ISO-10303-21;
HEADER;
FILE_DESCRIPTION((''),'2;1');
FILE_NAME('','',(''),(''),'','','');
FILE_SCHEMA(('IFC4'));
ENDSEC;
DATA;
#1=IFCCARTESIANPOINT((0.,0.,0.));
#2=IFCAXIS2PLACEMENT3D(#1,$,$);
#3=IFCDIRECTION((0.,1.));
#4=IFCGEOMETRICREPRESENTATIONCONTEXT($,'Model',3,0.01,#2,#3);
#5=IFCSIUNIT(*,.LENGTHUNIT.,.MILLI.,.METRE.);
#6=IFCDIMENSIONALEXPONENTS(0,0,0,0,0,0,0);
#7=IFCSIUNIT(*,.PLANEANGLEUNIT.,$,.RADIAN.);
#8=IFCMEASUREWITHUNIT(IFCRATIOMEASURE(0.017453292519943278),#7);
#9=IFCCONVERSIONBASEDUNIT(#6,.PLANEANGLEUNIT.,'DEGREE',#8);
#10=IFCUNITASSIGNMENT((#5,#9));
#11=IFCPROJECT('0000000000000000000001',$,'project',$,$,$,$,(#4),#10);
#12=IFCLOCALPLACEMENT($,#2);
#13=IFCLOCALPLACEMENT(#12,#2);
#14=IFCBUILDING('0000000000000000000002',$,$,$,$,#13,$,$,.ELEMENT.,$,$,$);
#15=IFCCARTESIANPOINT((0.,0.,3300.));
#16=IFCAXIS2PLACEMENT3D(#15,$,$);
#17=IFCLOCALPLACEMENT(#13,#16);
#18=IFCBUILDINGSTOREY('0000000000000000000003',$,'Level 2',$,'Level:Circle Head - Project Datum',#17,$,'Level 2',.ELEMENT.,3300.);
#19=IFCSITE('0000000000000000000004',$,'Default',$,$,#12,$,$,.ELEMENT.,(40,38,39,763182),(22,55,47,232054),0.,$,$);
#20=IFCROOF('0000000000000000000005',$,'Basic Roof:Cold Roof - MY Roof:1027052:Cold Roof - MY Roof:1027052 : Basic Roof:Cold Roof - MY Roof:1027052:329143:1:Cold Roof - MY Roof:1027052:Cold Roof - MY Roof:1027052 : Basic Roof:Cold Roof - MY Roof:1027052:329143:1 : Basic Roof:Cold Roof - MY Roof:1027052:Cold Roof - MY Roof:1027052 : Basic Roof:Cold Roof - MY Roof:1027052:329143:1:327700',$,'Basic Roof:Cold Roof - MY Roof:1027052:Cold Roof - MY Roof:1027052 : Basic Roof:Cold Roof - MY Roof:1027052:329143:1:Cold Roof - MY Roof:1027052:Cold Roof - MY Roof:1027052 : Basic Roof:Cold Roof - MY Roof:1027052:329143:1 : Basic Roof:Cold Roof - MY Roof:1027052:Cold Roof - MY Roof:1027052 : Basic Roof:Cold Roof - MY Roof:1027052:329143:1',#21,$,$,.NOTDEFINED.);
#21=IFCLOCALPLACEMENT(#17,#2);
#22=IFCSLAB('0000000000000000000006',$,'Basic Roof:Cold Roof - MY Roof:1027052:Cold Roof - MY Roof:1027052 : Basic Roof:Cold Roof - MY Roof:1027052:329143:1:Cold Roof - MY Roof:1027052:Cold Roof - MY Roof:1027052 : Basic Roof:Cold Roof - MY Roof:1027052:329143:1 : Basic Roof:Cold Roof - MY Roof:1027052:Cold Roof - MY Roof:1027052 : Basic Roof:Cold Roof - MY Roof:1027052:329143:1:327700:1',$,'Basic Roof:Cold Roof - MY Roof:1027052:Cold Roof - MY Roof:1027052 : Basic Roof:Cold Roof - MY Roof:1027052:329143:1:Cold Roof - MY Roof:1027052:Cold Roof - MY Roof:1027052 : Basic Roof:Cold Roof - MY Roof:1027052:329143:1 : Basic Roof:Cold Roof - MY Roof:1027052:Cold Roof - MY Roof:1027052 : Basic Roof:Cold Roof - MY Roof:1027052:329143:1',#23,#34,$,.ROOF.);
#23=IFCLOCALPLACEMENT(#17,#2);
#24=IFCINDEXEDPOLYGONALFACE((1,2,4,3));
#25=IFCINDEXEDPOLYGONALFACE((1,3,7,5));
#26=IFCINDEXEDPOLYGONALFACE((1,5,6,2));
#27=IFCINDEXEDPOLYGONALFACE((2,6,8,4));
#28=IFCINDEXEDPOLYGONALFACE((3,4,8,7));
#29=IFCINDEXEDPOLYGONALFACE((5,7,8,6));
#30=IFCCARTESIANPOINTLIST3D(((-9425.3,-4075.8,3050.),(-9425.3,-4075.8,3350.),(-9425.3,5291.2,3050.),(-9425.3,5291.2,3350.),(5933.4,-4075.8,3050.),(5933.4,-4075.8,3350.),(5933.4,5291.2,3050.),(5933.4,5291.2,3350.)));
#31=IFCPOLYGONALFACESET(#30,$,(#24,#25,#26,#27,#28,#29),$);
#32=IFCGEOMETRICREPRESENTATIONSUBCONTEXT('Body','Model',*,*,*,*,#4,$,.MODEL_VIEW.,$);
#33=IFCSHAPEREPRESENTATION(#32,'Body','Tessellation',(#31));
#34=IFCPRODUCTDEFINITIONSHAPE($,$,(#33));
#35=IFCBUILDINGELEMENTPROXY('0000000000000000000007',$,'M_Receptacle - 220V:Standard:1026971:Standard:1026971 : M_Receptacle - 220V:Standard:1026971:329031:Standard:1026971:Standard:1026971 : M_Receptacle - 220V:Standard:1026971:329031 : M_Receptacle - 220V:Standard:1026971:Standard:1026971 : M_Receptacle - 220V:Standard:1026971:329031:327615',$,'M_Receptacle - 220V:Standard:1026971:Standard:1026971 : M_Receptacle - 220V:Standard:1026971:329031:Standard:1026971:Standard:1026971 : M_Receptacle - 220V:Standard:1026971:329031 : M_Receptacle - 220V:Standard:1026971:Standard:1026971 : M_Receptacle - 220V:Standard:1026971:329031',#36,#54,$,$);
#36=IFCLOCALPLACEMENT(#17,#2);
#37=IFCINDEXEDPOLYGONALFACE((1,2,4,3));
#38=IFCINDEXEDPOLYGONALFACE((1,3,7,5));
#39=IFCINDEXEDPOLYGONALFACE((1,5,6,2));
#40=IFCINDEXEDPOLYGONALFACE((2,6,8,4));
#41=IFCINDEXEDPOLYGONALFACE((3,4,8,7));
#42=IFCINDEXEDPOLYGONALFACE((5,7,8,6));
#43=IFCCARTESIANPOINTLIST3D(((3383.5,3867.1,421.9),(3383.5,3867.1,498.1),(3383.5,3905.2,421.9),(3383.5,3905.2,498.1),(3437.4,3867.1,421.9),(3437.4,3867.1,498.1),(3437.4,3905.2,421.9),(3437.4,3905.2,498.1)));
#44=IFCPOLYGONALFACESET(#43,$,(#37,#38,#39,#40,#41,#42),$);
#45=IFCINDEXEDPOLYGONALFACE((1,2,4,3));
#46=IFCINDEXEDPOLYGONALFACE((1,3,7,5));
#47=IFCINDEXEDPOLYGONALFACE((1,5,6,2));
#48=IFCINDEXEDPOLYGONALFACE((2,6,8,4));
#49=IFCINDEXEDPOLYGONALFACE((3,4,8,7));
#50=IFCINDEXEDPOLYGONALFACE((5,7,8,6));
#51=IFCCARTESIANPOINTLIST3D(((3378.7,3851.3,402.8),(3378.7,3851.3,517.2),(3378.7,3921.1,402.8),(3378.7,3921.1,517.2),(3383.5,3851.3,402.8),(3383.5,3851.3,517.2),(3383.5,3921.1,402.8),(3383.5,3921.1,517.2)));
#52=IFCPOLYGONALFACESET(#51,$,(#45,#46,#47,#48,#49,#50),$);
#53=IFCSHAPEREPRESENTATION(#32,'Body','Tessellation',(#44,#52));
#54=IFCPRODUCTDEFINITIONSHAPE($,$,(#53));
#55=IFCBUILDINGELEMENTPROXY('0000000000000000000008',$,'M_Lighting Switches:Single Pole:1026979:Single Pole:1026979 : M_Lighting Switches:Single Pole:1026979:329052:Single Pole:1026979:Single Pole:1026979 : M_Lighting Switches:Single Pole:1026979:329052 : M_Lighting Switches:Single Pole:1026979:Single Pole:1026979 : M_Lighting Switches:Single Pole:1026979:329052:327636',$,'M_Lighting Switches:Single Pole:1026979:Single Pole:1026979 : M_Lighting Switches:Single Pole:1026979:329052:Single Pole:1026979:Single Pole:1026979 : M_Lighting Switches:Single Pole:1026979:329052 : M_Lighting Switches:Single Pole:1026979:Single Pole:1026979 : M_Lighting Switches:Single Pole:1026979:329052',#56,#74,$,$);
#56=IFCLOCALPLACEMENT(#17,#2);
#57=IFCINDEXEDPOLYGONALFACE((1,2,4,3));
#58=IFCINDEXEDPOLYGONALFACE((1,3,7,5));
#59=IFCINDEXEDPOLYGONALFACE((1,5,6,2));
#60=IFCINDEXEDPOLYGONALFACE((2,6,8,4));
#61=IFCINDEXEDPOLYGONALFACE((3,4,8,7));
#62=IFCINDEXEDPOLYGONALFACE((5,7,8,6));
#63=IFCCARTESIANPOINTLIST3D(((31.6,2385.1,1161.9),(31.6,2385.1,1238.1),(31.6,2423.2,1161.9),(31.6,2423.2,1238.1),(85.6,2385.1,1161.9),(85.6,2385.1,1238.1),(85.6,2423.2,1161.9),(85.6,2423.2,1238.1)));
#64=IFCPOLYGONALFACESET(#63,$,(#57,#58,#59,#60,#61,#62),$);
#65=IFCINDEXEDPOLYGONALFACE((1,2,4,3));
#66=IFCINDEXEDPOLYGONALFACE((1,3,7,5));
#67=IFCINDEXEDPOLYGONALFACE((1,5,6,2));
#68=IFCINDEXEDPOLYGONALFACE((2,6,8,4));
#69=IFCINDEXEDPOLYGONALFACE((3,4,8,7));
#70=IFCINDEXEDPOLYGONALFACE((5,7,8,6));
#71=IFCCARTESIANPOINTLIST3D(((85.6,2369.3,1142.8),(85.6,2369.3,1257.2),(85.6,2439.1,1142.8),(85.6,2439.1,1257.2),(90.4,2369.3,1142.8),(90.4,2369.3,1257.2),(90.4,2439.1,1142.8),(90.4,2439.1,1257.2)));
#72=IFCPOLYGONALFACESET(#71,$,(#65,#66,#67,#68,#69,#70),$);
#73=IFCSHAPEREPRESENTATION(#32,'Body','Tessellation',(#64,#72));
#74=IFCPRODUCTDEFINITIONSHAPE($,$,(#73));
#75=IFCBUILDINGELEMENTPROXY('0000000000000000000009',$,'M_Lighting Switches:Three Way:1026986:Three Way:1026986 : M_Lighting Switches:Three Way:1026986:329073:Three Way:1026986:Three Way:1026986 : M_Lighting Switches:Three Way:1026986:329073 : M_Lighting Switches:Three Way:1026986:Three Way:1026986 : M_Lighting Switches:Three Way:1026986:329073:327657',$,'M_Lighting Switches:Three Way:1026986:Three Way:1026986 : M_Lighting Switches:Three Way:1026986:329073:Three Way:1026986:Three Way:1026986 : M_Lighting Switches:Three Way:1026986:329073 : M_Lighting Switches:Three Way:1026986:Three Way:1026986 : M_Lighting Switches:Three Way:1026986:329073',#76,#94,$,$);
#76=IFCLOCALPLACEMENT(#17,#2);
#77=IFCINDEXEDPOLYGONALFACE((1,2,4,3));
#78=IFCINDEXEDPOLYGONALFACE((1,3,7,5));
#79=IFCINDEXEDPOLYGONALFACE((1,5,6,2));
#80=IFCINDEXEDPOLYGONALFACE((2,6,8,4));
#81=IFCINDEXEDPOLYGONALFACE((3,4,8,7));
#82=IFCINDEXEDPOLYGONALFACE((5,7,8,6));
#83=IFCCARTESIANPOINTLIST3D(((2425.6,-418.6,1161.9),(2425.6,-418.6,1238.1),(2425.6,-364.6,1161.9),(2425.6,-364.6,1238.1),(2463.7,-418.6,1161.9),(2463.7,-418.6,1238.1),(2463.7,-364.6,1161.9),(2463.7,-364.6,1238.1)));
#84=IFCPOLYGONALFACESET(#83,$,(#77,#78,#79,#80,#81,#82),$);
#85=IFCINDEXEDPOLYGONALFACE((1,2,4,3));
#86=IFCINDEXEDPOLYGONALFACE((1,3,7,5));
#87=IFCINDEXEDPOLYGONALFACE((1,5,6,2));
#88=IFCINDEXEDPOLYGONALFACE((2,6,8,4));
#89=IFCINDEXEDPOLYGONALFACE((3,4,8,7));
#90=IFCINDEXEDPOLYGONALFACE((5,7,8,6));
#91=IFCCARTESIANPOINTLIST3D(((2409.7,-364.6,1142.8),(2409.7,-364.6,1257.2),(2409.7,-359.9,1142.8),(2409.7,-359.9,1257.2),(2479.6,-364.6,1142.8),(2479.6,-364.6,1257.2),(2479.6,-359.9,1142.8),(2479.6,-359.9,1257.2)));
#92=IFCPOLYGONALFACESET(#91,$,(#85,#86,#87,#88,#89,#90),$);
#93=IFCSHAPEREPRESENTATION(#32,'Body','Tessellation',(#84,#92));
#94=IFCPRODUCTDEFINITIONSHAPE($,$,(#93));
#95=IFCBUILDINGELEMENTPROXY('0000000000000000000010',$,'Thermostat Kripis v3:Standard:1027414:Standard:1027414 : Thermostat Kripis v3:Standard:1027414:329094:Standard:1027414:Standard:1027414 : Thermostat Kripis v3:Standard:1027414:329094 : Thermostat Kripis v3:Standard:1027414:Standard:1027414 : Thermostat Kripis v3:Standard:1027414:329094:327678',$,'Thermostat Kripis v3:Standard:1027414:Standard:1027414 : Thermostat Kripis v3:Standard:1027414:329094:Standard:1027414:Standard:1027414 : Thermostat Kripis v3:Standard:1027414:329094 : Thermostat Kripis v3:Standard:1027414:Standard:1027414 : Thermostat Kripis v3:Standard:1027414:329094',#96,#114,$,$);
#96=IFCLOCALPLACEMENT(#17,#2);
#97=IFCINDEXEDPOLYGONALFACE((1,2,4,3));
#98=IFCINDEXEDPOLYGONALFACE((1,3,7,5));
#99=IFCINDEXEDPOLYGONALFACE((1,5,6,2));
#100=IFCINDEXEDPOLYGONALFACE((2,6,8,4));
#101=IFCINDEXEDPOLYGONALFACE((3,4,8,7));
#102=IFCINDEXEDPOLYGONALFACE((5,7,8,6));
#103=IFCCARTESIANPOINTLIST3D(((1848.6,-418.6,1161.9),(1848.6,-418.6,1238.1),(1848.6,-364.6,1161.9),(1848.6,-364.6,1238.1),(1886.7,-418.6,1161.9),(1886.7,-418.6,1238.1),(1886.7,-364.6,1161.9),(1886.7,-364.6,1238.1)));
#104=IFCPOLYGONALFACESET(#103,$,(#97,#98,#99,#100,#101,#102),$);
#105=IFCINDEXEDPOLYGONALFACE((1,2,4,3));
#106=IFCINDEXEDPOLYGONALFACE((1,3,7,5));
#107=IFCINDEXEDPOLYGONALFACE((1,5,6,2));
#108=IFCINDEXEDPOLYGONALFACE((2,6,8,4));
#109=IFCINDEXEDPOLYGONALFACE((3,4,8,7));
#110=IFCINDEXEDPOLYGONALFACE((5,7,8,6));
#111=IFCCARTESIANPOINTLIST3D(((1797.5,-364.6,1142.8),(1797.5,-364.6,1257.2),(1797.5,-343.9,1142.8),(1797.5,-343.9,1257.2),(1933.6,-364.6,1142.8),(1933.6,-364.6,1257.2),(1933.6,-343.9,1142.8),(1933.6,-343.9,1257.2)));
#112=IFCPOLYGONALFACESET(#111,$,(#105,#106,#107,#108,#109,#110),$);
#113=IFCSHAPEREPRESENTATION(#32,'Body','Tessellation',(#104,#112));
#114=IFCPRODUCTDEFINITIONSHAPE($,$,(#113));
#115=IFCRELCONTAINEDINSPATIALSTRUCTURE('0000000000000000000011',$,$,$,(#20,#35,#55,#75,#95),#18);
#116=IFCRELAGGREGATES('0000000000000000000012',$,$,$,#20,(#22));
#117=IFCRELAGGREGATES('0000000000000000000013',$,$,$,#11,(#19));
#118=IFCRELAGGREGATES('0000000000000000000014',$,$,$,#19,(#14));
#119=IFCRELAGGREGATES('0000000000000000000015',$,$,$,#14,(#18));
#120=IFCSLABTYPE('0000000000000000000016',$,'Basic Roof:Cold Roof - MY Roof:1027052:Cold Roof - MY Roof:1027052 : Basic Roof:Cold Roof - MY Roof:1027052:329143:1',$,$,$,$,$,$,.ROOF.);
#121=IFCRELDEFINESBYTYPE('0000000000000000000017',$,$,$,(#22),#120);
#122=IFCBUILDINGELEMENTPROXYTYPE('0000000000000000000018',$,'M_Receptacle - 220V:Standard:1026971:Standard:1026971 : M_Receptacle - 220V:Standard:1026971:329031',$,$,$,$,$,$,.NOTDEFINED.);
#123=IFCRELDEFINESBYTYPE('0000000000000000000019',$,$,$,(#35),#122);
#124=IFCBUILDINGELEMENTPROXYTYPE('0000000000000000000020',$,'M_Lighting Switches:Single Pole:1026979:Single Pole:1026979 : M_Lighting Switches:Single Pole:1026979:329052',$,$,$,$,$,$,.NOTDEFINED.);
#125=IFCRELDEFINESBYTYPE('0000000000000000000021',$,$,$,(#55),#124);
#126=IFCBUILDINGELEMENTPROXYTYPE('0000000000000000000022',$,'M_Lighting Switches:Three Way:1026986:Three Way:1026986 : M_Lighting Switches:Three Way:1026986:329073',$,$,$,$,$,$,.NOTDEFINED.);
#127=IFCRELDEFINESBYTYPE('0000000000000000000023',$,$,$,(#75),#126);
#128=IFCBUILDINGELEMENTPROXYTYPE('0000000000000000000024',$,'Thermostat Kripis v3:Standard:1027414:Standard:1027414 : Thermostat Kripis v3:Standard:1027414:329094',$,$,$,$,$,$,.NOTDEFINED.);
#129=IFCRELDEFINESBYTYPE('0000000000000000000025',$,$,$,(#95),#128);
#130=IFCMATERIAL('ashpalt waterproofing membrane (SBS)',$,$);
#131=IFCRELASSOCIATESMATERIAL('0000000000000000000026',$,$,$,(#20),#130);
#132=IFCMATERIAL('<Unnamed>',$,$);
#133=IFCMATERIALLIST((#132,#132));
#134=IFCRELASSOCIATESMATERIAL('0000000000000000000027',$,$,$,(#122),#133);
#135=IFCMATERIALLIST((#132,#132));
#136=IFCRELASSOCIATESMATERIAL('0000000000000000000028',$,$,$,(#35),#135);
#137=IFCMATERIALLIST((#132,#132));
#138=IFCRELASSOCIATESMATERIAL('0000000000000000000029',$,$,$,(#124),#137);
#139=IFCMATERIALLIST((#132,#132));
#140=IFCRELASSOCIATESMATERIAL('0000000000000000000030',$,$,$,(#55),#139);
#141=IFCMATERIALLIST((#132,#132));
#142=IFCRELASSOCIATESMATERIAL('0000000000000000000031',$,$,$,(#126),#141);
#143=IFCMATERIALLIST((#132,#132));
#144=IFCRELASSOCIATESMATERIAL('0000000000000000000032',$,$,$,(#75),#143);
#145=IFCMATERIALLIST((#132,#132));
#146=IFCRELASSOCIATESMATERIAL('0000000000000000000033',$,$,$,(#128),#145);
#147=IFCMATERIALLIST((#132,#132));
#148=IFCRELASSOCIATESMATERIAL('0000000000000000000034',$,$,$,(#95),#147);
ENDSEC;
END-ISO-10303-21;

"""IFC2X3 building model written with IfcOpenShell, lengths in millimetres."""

from ifc_helpers import new_model, entity, si_unit, converted_unit, direction, frame, frame_2d, origin, origin_2d_with_axis, place, context, subcontext, project, spatial, rectangle, extrude, source, transform, mapped, material, material_list, type_object, type_shapes, element, aggregate, save


model = new_model("IFC2X3")

# Units and contexts
model_context = context("Model", 3, precision=0.01, world=origin(), true_north=direction((0.0, 1.0)))
body_context = subcontext(model_context, "Body", "Model", "MODEL_VIEW")
ifc_project = project(units=[si_unit("LENGTHUNIT", "METRE", prefix="MILLI"), converted_unit("PLANEANGLEUNIT", "DEGREE", entity("IfcRatioMeasure", 0.017453292519943278), si_unit("PLANEANGLEUNIT", "RADIAN"), dimensions=[0, 0, 0, 0, 0, 0, 0])], contexts=[model_context])

# Site, building, storey
site_placement = place(None, origin())
site = spatial("IfcSite", under=ifc_project, at=site_placement, Name="Default", CompositionType="ELEMENT", RefLatitude=(40, 38, 39, 763182), RefLongitude=(22, 55, 47, 232054), RefElevation=0.0)
building_placement = place(site_placement, origin())
building = spatial("IfcBuilding", under=site, at=building_placement, CompositionType="ELEMENT")
storey_placement = place(building_placement, frame((0.0, 0.0, 3300.0)))
storey = spatial("IfcBuildingStorey", under=building, at=storey_placement, Name="Level 2", ObjectType="Level:Circle Head - Project Datum", LongName="Level 2", CompositionType="ELEMENT", Elevation=3300.0)

# Roof, slab
ifc_material_1 = material(Name="ashpalt waterproofing membrane (SBS)")
roof_placement = place(storey_placement, origin())
roof = element("IfcRoof", 1, at=roof_placement, inside=storey, material=ifc_material_1, Name="Basic Roof:Cold Roof - MY Roof:1027052:Cold Roof - MY Roof:1027052 : Basic Roof:Cold Roof - MY Roof:1027052:329143:1:Cold Roof - MY Roof:1027052:Cold Roof - MY Roof:1027052 : Basic Roof:Cold Roof - MY Roof:1027052:329143:1 : Basic Roof:Cold Roof - MY Roof:1027052:Cold Roof - MY Roof:1027052 : Basic Roof:Cold Roof - MY Roof:1027052:329143:1:327700", ObjectType="Basic Roof:Cold Roof - MY Roof:1027052:Cold Roof - MY Roof:1027052 : Basic Roof:Cold Roof - MY Roof:1027052:329143:1:Cold Roof - MY Roof:1027052:Cold Roof - MY Roof:1027052 : Basic Roof:Cold Roof - MY Roof:1027052:329143:1 : Basic Roof:Cold Roof - MY Roof:1027052:Cold Roof - MY Roof:1027052 : Basic Roof:Cold Roof - MY Roof:1027052:329143:1", ShapeType="NOTDEFINED")
slab_type = type_object("IfcSlabType", Name="Basic Roof:Cold Roof - MY Roof:1027052:Cold Roof - MY Roof:1027052 : Basic Roof:Cold Roof - MY Roof:1027052:329143:1", PredefinedType="ROOF")
slab_placement = place(storey_placement, origin())
slab = element("IfcSlab", 2, at=slab_placement, type_object=slab_type, Name="Basic Roof:Cold Roof - MY Roof:1027052:Cold Roof - MY Roof:1027052 : Basic Roof:Cold Roof - MY Roof:1027052:329143:1:Cold Roof - MY Roof:1027052:Cold Roof - MY Roof:1027052 : Basic Roof:Cold Roof - MY Roof:1027052:329143:1 : Basic Roof:Cold Roof - MY Roof:1027052:Cold Roof - MY Roof:1027052 : Basic Roof:Cold Roof - MY Roof:1027052:329143:1:327700:1", ObjectType="Basic Roof:Cold Roof - MY Roof:1027052:Cold Roof - MY Roof:1027052 : Basic Roof:Cold Roof - MY Roof:1027052:329143:1:Cold Roof - MY Roof:1027052:Cold Roof - MY Roof:1027052 : Basic Roof:Cold Roof - MY Roof:1027052:329143:1 : Basic Roof:Cold Roof - MY Roof:1027052:Cold Roof - MY Roof:1027052 : Basic Roof:Cold Roof - MY Roof:1027052:329143:1", PredefinedType="ROOF", context=body_context, shape_type="SweptSolid", body=[
    extrude(rectangle(XDim=15358.7, YDim=9367.0, at=frame_2d((0.0, 0.0), x_axis=(1.0, 0.0))), frame((-1746.0, 607.7, 3050.0), z_axis=(0.0, 0.0, 1.0), x_axis=(-1.0, 0.0, 0.0)), (0.0, 0.0, 1.0), 300.0),
])
aggregate(roof, [slab])

# Shared definitions
ifc_material_2 = material(Name="<Unnamed>")

# Building element proxies
ifc_material_list_1 = material_list([ifc_material_2, ifc_material_2])
ifc_material_list_2 = material_list([ifc_material_2, ifc_material_2])
building_element_proxy_type_1 = type_object("IfcBuildingElementProxyType", Name="M_Receptacle - 220V:Standard:1026971:Standard:1026971 : M_Receptacle - 220V:Standard:1026971:329031", PredefinedType="NOTDEFINED", material=ifc_material_list_2)
shared_shape_1 = source(origin(), body_context, "Body", "SweptSolid", [
    extrude(rectangle(XDim=38.1, YDim=54.0, at=frame_2d((0.0, 0.0), x_axis=(1.0, 0.0))), frame((3410.4, 3886.2, 3721.9), z_axis=(0.0, 0.0, 1.0), x_axis=(0.0, 1.0, 0.0)), (0.0, 0.0, 1.0), 76.2),
    extrude(rectangle(XDim=69.8, YDim=4.8, at=frame_2d((0.0, 0.0), x_axis=(1.0, 0.0))), frame((3381.1, 3886.2, 3702.8), z_axis=(0.0, 0.0, 1.0), x_axis=(0.0, 1.0, 0.0)), (0.0, 0.0, 1.0), 114.3),
])
type_shapes(building_element_proxy_type_1, [shared_shape_1])
proxy_1_placement = place(storey_placement, frame((0.0, 0.0, -3300.0)))
element("IfcBuildingElementProxy", 3, at=proxy_1_placement, inside=storey, type_object=building_element_proxy_type_1, material=ifc_material_list_1, Name="M_Receptacle - 220V:Standard:1026971:Standard:1026971 : M_Receptacle - 220V:Standard:1026971:329031:Standard:1026971:Standard:1026971 : M_Receptacle - 220V:Standard:1026971:329031 : M_Receptacle - 220V:Standard:1026971:Standard:1026971 : M_Receptacle - 220V:Standard:1026971:329031:327615", ObjectType="M_Receptacle - 220V:Standard:1026971:Standard:1026971 : M_Receptacle - 220V:Standard:1026971:329031:Standard:1026971:Standard:1026971 : M_Receptacle - 220V:Standard:1026971:329031 : M_Receptacle - 220V:Standard:1026971:Standard:1026971 : M_Receptacle - 220V:Standard:1026971:329031", context=body_context, shape_type="MappedRepresentation", body=[
    mapped(shared_shape_1, transform((0.0, 0.0, 0.0), scale=1.0)),
])
ifc_material_list_3 = material_list([ifc_material_2, ifc_material_2])
ifc_material_list_4 = material_list([ifc_material_2, ifc_material_2])
building_element_proxy_type_2 = type_object("IfcBuildingElementProxyType", Name="M_Lighting Switches:Single Pole:1026979:Single Pole:1026979 : M_Lighting Switches:Single Pole:1026979:329052", PredefinedType="NOTDEFINED", material=ifc_material_list_4)
shared_shape_2 = source(origin(), body_context, "Body", "SweptSolid", [
    extrude(rectangle(XDim=38.1, YDim=54.0, at=origin_2d_with_axis()), frame((58.6, 2404.2, 4461.9), z_axis=(0.0, 0.0, 1.0), x_axis=(0.0, -1.0, 0.0)), (0.0, 0.0, 1.0), 76.2),
    extrude(rectangle(XDim=69.8, YDim=4.8, at=frame_2d((0.0, 0.0), x_axis=(1.0, 0.0))), frame((88.0, 2404.2, 4442.8), z_axis=(0.0, 0.0, 1.0), x_axis=(0.0, -1.0, 0.0)), (0.0, 0.0, 1.0), 114.3),
])
type_shapes(building_element_proxy_type_2, [shared_shape_2])
proxy_2_placement = place(storey_placement, frame((0.0, 0.0, -3300.0)))
element("IfcBuildingElementProxy", 4, at=proxy_2_placement, inside=storey, type_object=building_element_proxy_type_2, material=ifc_material_list_3, Name="M_Lighting Switches:Single Pole:1026979:Single Pole:1026979 : M_Lighting Switches:Single Pole:1026979:329052:Single Pole:1026979:Single Pole:1026979 : M_Lighting Switches:Single Pole:1026979:329052 : M_Lighting Switches:Single Pole:1026979:Single Pole:1026979 : M_Lighting Switches:Single Pole:1026979:329052:327636", ObjectType="M_Lighting Switches:Single Pole:1026979:Single Pole:1026979 : M_Lighting Switches:Single Pole:1026979:329052:Single Pole:1026979:Single Pole:1026979 : M_Lighting Switches:Single Pole:1026979:329052 : M_Lighting Switches:Single Pole:1026979:Single Pole:1026979 : M_Lighting Switches:Single Pole:1026979:329052", context=body_context, shape_type="MappedRepresentation", body=[
    mapped(shared_shape_2, transform((0.0, 0.0, 0.0), scale=1.0)),
])
ifc_material_list_5 = material_list([ifc_material_2, ifc_material_2])
ifc_material_list_6 = material_list([ifc_material_2, ifc_material_2])
building_element_proxy_type_3 = type_object("IfcBuildingElementProxyType", Name="M_Lighting Switches:Three Way:1026986:Three Way:1026986 : M_Lighting Switches:Three Way:1026986:329073", PredefinedType="NOTDEFINED", material=ifc_material_list_6)
shared_shape_3 = source(origin(), body_context, "Body", "SweptSolid", [
    extrude(rectangle(XDim=38.1, YDim=54.0, at=frame_2d((0.0, 0.0), x_axis=(1.0, 0.0))), frame((2444.7, -391.6, 4461.9)), (0.0, 0.0, 1.0), 76.2),
    extrude(rectangle(XDim=69.8, YDim=4.8, at=frame_2d((0.0, 0.0), x_axis=(1.0, 0.0))), frame((2444.7, -362.3, 4442.8)), (0.0, 0.0, 1.0), 114.3),
])
type_shapes(building_element_proxy_type_3, [shared_shape_3])
proxy_3_placement = place(storey_placement, frame((0.0, 0.0, -3300.0)))
element("IfcBuildingElementProxy", 5, at=proxy_3_placement, inside=storey, type_object=building_element_proxy_type_3, material=ifc_material_list_5, Name="M_Lighting Switches:Three Way:1026986:Three Way:1026986 : M_Lighting Switches:Three Way:1026986:329073:Three Way:1026986:Three Way:1026986 : M_Lighting Switches:Three Way:1026986:329073 : M_Lighting Switches:Three Way:1026986:Three Way:1026986 : M_Lighting Switches:Three Way:1026986:329073:327657", ObjectType="M_Lighting Switches:Three Way:1026986:Three Way:1026986 : M_Lighting Switches:Three Way:1026986:329073:Three Way:1026986:Three Way:1026986 : M_Lighting Switches:Three Way:1026986:329073 : M_Lighting Switches:Three Way:1026986:Three Way:1026986 : M_Lighting Switches:Three Way:1026986:329073", context=body_context, shape_type="MappedRepresentation", body=[
    mapped(shared_shape_3, transform((0.0, 0.0, 0.0), scale=1.0)),
])
ifc_material_list_7 = material_list([ifc_material_2, ifc_material_2])
ifc_material_list_8 = material_list([ifc_material_2, ifc_material_2])
building_element_proxy_type_4 = type_object("IfcBuildingElementProxyType", Name="Thermostat Kripis v3:Standard:1027414:Standard:1027414 : Thermostat Kripis v3:Standard:1027414:329094", PredefinedType="NOTDEFINED", material=ifc_material_list_8)
shared_shape_4 = source(origin(), body_context, "Body", "SweptSolid", [
    extrude(rectangle(XDim=38.1, YDim=54.0, at=origin_2d_with_axis()), frame((1867.6, -391.6, 4461.9)), (0.0, 0.0, 1.0), 76.2),
    extrude(rectangle(XDim=136.0, YDim=20.7, at=frame_2d((0.0, 0.0), x_axis=(1.0, 0.0))), frame((1865.5, -354.3, 4442.8)), (0.0, 0.0, 1.0), 114.3),
])
type_shapes(building_element_proxy_type_4, [shared_shape_4])
proxy_4_placement = place(storey_placement, frame((0.0, 0.0, -3300.0)))
element("IfcBuildingElementProxy", 6, at=proxy_4_placement, inside=storey, type_object=building_element_proxy_type_4, material=ifc_material_list_7, Name="Thermostat Kripis v3:Standard:1027414:Standard:1027414 : Thermostat Kripis v3:Standard:1027414:329094:Standard:1027414:Standard:1027414 : Thermostat Kripis v3:Standard:1027414:329094 : Thermostat Kripis v3:Standard:1027414:Standard:1027414 : Thermostat Kripis v3:Standard:1027414:329094:327678", ObjectType="Thermostat Kripis v3:Standard:1027414:Standard:1027414 : Thermostat Kripis v3:Standard:1027414:329094:Standard:1027414:Standard:1027414 : Thermostat Kripis v3:Standard:1027414:329094 : Thermostat Kripis v3:Standard:1027414:Standard:1027414 : Thermostat Kripis v3:Standard:1027414:329094", context=body_context, shape_type="MappedRepresentation", body=[
    mapped(shared_shape_4, transform((0.0, 0.0, 0.0), scale=1.0)),
])

save(model, "model.ifc")
